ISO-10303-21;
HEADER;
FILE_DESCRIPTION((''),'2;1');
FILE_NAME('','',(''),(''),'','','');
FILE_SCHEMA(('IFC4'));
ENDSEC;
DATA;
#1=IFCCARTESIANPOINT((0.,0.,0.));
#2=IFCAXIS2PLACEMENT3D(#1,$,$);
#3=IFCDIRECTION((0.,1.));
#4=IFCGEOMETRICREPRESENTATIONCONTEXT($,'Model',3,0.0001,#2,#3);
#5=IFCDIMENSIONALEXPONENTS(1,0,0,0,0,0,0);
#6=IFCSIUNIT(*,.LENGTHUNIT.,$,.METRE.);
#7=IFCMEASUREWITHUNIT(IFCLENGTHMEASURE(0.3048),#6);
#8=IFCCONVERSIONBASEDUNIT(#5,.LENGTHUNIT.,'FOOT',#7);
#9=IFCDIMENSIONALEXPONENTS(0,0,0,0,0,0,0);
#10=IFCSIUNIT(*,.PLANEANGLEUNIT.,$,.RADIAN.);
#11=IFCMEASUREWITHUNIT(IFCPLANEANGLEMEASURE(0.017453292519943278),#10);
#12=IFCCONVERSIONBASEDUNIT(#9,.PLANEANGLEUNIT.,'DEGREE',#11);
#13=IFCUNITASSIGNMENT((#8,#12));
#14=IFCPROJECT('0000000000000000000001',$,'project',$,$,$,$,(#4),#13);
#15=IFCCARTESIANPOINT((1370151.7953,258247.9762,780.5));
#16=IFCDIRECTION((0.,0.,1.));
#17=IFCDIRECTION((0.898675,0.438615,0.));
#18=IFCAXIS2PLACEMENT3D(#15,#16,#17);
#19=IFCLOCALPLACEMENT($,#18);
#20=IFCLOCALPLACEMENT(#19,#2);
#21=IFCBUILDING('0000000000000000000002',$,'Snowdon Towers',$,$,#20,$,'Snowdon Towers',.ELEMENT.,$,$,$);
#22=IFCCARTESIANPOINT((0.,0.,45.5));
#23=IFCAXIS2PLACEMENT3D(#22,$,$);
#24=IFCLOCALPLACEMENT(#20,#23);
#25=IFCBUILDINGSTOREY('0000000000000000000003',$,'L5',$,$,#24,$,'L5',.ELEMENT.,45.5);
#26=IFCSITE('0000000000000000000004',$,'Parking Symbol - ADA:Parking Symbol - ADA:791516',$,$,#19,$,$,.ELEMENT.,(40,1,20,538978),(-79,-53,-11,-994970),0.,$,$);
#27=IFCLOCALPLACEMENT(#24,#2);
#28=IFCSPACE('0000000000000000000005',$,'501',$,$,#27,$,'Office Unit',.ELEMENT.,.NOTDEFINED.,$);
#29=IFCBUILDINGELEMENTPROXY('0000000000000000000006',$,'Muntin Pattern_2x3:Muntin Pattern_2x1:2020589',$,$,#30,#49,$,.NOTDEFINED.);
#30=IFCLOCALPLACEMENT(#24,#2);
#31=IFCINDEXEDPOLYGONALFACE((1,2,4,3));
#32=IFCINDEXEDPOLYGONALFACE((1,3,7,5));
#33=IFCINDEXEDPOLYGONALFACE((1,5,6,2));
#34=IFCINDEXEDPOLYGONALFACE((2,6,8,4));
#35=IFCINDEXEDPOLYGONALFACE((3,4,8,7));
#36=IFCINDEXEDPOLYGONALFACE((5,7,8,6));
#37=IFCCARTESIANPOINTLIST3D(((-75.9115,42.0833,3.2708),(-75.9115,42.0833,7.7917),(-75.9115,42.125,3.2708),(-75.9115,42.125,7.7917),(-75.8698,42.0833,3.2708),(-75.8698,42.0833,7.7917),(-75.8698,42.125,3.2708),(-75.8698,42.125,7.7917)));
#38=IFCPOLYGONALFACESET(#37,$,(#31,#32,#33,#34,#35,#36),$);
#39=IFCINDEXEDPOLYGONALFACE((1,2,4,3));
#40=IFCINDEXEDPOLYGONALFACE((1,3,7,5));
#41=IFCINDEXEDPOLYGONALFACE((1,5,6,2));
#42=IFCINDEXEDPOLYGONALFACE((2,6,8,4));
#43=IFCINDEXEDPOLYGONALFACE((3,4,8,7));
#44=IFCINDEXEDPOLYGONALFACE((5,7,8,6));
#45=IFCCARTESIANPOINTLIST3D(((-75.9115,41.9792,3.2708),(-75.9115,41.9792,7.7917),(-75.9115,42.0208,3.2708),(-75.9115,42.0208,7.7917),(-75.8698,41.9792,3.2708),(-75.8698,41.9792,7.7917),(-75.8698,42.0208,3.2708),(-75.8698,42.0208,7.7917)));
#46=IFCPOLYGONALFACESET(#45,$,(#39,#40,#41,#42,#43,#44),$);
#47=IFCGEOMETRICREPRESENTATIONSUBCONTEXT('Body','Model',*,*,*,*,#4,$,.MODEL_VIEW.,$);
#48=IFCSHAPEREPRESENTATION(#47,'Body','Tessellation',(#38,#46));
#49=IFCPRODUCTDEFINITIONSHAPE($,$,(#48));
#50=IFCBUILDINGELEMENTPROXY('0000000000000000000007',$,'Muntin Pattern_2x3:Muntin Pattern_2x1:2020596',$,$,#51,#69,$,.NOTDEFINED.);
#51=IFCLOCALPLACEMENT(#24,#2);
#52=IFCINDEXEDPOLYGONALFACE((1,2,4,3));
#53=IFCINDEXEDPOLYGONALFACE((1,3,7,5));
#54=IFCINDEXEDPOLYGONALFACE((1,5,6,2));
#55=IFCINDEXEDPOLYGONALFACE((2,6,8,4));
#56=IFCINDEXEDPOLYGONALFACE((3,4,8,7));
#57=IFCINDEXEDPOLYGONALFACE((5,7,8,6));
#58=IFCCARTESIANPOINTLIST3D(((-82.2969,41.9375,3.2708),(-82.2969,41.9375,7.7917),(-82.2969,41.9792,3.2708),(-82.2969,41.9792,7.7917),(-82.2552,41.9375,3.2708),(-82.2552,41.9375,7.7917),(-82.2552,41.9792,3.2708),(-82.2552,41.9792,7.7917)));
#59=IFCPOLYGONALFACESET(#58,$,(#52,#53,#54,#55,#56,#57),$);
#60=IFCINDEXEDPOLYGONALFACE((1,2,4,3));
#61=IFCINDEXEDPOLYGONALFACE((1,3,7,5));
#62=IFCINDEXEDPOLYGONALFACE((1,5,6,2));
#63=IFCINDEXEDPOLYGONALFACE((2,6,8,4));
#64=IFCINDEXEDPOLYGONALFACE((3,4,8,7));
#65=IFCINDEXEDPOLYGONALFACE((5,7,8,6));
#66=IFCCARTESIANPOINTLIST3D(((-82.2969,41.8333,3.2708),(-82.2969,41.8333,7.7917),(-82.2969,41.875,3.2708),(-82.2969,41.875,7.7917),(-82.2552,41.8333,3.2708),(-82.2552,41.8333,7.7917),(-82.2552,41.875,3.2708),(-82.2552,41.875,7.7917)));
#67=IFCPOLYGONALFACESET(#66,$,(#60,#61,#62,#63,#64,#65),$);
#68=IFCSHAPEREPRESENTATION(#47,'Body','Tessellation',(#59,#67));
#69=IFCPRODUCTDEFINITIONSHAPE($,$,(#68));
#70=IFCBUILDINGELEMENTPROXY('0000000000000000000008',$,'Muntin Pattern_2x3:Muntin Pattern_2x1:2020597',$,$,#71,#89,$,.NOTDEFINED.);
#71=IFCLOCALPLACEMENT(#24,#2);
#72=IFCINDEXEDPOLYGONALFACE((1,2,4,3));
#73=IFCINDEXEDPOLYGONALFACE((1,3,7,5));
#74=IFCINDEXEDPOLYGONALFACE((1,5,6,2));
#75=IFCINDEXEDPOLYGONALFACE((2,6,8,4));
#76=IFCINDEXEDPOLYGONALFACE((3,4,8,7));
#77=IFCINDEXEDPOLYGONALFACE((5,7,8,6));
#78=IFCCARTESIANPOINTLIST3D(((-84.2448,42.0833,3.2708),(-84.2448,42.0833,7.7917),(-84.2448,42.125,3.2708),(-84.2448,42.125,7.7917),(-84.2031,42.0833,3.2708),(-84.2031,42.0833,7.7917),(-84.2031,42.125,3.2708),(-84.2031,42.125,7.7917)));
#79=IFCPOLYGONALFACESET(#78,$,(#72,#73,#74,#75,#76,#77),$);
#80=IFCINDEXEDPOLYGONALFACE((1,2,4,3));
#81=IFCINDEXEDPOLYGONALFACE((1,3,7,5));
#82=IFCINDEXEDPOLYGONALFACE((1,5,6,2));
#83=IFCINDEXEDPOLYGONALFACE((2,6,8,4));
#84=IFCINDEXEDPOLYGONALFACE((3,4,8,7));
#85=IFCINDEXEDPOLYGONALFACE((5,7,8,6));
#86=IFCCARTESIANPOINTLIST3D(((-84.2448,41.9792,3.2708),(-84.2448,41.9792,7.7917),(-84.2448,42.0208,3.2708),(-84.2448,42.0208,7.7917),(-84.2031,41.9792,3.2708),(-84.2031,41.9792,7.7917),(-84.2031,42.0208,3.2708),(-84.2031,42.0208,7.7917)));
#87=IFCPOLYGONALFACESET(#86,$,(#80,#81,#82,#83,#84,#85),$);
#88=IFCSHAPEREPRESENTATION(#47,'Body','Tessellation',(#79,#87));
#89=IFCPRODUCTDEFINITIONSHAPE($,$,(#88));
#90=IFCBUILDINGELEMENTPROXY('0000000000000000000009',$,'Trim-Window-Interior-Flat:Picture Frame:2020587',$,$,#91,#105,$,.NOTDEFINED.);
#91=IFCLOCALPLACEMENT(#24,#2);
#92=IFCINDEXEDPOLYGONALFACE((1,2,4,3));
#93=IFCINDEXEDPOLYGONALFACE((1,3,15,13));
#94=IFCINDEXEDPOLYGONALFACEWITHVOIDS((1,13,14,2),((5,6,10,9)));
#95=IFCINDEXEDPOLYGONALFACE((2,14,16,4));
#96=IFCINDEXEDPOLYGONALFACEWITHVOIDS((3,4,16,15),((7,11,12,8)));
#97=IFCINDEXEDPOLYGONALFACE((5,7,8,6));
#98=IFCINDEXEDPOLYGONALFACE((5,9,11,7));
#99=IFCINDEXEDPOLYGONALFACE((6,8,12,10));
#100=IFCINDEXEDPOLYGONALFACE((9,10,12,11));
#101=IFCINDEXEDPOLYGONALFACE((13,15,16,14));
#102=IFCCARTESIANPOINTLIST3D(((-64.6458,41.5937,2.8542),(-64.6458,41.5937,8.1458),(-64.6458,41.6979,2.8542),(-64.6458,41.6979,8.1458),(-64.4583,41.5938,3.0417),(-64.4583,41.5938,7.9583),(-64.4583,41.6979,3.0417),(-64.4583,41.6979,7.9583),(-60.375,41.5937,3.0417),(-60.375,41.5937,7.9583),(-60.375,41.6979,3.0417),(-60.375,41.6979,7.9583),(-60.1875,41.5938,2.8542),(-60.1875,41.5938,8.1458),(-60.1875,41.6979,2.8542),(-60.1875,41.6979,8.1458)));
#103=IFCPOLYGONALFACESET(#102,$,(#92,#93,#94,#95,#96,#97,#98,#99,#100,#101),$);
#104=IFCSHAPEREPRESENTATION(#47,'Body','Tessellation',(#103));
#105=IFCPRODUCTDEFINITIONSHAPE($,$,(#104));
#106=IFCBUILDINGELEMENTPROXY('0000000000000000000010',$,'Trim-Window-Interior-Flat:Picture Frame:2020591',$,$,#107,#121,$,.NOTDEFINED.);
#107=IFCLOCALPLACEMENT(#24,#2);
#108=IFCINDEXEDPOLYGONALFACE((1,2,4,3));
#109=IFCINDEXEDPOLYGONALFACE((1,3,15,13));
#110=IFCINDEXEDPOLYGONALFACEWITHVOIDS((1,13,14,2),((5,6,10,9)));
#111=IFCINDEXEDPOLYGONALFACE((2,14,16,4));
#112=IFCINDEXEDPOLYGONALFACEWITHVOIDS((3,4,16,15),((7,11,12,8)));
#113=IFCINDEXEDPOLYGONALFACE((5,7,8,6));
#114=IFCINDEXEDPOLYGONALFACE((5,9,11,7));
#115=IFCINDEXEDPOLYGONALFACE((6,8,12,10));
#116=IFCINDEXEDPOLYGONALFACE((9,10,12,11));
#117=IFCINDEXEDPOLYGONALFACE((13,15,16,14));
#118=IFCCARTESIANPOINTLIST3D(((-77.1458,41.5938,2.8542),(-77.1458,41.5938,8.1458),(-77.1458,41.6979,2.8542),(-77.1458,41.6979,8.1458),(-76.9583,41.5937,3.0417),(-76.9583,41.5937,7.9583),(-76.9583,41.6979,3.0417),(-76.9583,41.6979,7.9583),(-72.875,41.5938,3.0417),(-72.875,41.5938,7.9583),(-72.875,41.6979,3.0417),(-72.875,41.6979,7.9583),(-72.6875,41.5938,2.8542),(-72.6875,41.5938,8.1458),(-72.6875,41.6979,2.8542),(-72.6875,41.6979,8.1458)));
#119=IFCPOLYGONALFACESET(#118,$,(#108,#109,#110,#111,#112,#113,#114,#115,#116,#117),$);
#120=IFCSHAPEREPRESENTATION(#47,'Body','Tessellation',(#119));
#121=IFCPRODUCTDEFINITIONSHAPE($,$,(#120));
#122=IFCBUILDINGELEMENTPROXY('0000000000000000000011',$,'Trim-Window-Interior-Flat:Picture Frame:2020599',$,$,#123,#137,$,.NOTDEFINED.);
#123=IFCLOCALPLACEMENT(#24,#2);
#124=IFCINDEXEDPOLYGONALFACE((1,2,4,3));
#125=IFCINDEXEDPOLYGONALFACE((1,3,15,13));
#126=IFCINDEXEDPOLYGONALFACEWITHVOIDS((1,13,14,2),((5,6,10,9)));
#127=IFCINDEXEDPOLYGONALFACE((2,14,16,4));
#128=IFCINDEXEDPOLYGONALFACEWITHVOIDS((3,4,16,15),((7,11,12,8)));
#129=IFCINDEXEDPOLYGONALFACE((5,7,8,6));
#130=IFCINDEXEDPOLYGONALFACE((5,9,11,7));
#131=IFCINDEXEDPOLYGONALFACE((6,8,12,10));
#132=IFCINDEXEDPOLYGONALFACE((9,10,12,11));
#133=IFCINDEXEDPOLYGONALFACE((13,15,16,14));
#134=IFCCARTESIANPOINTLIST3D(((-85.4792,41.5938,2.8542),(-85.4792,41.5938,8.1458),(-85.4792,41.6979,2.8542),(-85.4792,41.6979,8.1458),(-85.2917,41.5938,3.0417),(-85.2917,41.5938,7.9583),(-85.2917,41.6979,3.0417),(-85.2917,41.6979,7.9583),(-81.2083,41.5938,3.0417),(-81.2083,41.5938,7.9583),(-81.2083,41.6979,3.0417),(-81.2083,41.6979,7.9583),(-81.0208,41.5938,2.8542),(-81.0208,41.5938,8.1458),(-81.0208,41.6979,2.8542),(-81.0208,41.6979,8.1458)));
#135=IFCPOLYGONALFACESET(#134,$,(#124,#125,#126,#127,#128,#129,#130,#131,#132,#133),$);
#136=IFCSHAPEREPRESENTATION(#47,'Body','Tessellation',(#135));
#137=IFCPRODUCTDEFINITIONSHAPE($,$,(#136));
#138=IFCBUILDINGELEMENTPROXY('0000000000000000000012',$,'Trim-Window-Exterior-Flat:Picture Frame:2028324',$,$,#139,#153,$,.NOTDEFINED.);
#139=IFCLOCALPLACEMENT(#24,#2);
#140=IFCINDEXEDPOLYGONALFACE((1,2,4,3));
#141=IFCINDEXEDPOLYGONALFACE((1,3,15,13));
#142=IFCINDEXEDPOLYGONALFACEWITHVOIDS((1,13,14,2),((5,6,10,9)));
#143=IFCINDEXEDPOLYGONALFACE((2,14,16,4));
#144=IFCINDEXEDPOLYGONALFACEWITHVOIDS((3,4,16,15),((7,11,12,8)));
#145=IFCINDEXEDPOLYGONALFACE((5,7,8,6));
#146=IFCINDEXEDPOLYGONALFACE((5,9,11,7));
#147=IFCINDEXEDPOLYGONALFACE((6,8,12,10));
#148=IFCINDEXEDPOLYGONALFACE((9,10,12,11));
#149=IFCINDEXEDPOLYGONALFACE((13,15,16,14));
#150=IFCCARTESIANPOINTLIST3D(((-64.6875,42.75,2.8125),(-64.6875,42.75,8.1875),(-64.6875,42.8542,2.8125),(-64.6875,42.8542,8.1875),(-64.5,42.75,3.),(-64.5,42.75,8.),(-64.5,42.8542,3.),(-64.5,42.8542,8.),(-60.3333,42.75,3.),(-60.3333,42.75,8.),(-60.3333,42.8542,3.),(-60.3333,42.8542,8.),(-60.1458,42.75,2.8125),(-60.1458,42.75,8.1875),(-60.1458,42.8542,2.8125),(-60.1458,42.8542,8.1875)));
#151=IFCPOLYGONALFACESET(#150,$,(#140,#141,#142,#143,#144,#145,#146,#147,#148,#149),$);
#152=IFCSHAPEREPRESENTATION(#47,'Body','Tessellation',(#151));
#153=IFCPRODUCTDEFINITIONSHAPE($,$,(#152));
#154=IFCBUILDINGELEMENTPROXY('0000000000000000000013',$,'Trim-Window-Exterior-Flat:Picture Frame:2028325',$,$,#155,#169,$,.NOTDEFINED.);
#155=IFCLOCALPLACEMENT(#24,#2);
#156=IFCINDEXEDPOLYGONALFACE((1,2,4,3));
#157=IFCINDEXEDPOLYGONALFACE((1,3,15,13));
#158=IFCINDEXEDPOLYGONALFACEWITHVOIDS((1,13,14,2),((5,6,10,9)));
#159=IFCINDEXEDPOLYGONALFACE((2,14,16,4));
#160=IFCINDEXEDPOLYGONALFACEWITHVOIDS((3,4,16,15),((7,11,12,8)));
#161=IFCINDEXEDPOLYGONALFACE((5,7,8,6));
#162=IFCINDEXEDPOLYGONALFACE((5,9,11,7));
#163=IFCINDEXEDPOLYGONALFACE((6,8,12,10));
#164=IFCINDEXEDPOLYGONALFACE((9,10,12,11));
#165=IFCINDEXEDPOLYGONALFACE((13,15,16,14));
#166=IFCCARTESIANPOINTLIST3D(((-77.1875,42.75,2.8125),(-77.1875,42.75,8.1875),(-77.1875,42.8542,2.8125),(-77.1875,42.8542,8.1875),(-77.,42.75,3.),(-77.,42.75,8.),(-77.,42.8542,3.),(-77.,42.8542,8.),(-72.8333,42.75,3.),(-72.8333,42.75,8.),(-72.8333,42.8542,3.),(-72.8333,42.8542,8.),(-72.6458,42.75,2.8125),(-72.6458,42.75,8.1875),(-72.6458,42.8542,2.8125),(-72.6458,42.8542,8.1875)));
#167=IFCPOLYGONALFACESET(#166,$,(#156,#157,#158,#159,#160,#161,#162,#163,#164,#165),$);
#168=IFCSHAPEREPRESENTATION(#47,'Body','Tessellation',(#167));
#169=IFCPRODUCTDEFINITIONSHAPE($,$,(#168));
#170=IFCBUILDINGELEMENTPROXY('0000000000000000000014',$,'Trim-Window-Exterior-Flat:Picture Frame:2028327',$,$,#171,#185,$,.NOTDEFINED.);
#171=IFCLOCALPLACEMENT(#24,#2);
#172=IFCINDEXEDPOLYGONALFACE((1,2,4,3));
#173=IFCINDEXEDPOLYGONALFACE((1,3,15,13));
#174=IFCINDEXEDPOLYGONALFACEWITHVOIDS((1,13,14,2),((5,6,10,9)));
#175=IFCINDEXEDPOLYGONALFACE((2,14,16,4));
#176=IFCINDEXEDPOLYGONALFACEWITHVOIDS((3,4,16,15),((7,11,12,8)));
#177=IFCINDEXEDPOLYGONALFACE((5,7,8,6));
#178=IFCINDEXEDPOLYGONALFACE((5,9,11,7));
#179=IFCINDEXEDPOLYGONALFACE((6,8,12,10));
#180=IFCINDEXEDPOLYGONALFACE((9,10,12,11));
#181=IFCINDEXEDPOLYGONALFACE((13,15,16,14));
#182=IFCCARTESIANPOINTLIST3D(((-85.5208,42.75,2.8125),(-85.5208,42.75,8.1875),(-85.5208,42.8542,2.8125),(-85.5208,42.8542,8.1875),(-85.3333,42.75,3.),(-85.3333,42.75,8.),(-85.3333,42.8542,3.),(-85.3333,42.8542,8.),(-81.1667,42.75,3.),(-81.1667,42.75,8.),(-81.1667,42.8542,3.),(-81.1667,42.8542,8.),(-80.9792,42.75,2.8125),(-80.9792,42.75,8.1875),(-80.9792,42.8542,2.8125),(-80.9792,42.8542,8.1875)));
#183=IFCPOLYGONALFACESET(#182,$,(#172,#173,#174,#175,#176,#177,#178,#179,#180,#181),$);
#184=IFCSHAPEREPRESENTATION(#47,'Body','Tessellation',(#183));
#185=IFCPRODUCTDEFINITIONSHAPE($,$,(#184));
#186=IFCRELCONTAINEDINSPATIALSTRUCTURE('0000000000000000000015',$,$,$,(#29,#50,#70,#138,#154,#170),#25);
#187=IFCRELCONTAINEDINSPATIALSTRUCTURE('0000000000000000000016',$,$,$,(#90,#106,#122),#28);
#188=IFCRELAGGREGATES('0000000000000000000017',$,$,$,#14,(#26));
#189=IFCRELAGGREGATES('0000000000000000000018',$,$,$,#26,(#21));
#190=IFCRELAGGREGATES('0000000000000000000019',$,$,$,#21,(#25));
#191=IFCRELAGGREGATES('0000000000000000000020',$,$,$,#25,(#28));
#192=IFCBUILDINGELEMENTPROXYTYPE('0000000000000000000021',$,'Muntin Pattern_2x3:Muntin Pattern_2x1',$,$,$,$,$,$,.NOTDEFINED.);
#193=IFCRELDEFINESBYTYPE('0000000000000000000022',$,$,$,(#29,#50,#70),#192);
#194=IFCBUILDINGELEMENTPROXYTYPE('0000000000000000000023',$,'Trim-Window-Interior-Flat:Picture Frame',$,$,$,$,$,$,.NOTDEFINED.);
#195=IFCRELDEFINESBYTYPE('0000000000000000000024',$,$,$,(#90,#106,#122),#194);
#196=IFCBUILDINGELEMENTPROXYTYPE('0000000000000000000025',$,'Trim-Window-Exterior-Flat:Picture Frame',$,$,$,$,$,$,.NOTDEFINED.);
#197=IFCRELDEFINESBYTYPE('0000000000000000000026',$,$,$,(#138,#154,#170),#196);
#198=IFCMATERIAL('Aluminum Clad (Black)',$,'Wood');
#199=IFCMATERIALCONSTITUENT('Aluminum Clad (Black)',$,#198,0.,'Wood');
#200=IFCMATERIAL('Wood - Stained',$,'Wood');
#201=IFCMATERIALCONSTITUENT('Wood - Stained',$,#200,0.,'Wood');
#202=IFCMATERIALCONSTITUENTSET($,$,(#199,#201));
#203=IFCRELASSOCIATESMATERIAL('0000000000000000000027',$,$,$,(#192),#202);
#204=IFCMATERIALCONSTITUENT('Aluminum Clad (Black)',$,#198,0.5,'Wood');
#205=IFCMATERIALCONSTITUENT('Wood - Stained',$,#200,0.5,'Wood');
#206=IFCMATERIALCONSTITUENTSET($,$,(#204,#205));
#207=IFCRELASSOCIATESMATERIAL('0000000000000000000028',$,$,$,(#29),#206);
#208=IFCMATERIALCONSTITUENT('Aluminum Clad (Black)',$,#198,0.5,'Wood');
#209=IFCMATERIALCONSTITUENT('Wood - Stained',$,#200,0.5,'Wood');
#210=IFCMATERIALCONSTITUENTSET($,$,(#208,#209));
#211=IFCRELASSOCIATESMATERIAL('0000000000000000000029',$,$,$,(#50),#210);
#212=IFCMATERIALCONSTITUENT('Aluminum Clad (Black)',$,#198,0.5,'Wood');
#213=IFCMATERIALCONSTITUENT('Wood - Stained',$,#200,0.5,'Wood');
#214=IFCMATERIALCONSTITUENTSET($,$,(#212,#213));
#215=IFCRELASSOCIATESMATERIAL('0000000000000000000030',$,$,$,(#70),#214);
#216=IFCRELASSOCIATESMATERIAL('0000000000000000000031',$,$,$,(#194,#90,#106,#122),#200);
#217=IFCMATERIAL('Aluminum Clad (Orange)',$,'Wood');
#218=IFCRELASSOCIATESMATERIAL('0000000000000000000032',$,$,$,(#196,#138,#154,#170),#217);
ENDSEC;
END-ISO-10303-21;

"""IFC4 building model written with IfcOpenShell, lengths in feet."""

from ifc_helpers import new_model, entity, si_unit, converted_unit, direction, frame, origin, place, context, subcontext, project, spatial, indexed_curve, outline, extrude, source, transform, mapped, material, constituent, constituent_set, type_object, type_shapes, element, save


model = new_model("IFC4")

# Units and contexts
model_context = context("Model", 3, precision=0.0001, world=origin(), true_north=direction((0.0, 1.0)))
body_context = subcontext(model_context, "Body", "Model", "MODEL_VIEW")
ifc_project = project(units=[converted_unit("LENGTHUNIT", "FOOT", entity("IfcLengthMeasure", 0.3048), si_unit("LENGTHUNIT", "METRE"), dimensions=[1, 0, 0, 0, 0, 0, 0]), converted_unit("PLANEANGLEUNIT", "DEGREE", entity("IfcPlaneAngleMeasure", 0.017453292519943278), si_unit("PLANEANGLEUNIT", "RADIAN"), dimensions=[0, 0, 0, 0, 0, 0, 0])], contexts=[model_context])

# Site, building, storey
site_placement = place(None, frame((1370151.7953, 258247.9762, 780.5), z_axis=(0.0, 0.0, 1.0), x_axis=(0.898675, 0.438615, 0.0)))
site = spatial("IfcSite", under=ifc_project, at=site_placement, Name="Parking Symbol - ADA:Parking Symbol - ADA:791516", CompositionType="ELEMENT", RefLatitude=(40, 1, 20, 538978), RefLongitude=(-79, -53, -11, -994970), RefElevation=0.0)
building_placement = place(site_placement, origin())
building = spatial("IfcBuilding", under=site, at=building_placement, Name="Snowdon Towers", LongName="Snowdon Towers", CompositionType="ELEMENT")
storey_placement = place(building_placement, frame((0.0, 0.0, 45.5)))
storey = spatial("IfcBuildingStorey", under=building, at=storey_placement, Name="L5", LongName="L5", CompositionType="ELEMENT", Elevation=45.5)

# Building element proxies
ifc_material_1 = material(Name="Aluminum Clad (Black)", Category="Wood")
ifc_material_2 = material(Name="Wood - Stained", Category="Wood")
ifc_constituent_1 = constituent(ifc_material_1, Name="Aluminum Clad (Black)", Category="Wood", fraction=0.0)
ifc_constituent_2 = constituent(ifc_material_2, Name="Wood - Stained", Category="Wood", fraction=0.0)
ifc_constituent_set_1 = constituent_set(constituents=[ifc_constituent_1, ifc_constituent_2])
building_element_proxy_type_1 = type_object("IfcBuildingElementProxyType", Name="Muntin Pattern_2x3:Muntin Pattern_2x1", PredefinedType="NOTDEFINED", material=ifc_constituent_set_1)
shared_shape_1 = source(origin(), body_context, "Body", "SweptSolid", [
    extrude(outline(indexed_curve([(-0.0208, -0.0208), (0.0208, -0.0208), (0.0208, 0.0208), (-0.0208, 0.0208), (-0.0208, -0.0208)], self_intersect=False)), frame((0.0, 0.0521, 0.0), z_axis=(0.0, 0.0, 1.0), x_axis=(0.0, -1.0, 0.0)), (0.0, 0.0, 1.0), 4.5208),
    extrude(outline(indexed_curve([(-0.0208, -0.0208), (0.0208, -0.0208), (0.0208, 0.0208), (-0.0208, 0.0208), (-0.0208, -0.0208)], self_intersect=False)), frame((0.0, -0.0521, 0.0), z_axis=(0.0, 0.0, 1.0), x_axis=(0.0, -1.0, 0.0)), (0.0, 0.0, 1.0), 4.5208),
])
type_shapes(building_element_proxy_type_1, [shared_shape_1])
ifc_constituent_3 = constituent(ifc_material_1, Name="Aluminum Clad (Black)", Category="Wood", fraction=0.5)
ifc_constituent_4 = constituent(ifc_material_2, Name="Wood - Stained", Category="Wood", fraction=0.5)
ifc_constituent_set_2 = constituent_set(constituents=[ifc_constituent_3, ifc_constituent_4])
proxy_1_placement = place(storey_placement, frame((-75.8906, 42.0521, 3.2708)))
element("IfcBuildingElementProxy", 1, at=proxy_1_placement, inside=storey, type_object=building_element_proxy_type_1, material=ifc_constituent_set_2, Name="Muntin Pattern_2x3:Muntin Pattern_2x1:2020589", PredefinedType="NOTDEFINED", context=body_context, shape_type="MappedRepresentation", body=[
    mapped(shared_shape_1, transform((0.0, 0.0, 0.0), scale=1.0)),
])
ifc_constituent_5 = constituent(ifc_material_1, Name="Aluminum Clad (Black)", Category="Wood", fraction=0.5)
ifc_constituent_6 = constituent(ifc_material_2, Name="Wood - Stained", Category="Wood", fraction=0.5)
ifc_constituent_set_3 = constituent_set(constituents=[ifc_constituent_5, ifc_constituent_6])
proxy_2_placement = place(storey_placement, frame((-82.276, 41.9063, 3.2708)))
element("IfcBuildingElementProxy", 2, at=proxy_2_placement, inside=storey, type_object=building_element_proxy_type_1, material=ifc_constituent_set_3, Name="Muntin Pattern_2x3:Muntin Pattern_2x1:2020596", PredefinedType="NOTDEFINED", context=body_context, shape_type="MappedRepresentation", body=[
    mapped(shared_shape_1, transform((0.0, 0.0, 0.0), scale=1.0)),
])
ifc_constituent_7 = constituent(ifc_material_1, Name="Aluminum Clad (Black)", Category="Wood", fraction=0.5)
ifc_constituent_8 = constituent(ifc_material_2, Name="Wood - Stained", Category="Wood", fraction=0.5)
ifc_constituent_set_4 = constituent_set(constituents=[ifc_constituent_7, ifc_constituent_8])
proxy_3_placement = place(storey_placement, frame((-84.224, 42.0521, 3.2708)))
element("IfcBuildingElementProxy", 3, at=proxy_3_placement, inside=storey, type_object=building_element_proxy_type_1, material=ifc_constituent_set_4, Name="Muntin Pattern_2x3:Muntin Pattern_2x1:2020597", PredefinedType="NOTDEFINED", context=body_context, shape_type="MappedRepresentation", body=[
    mapped(shared_shape_1, transform((0.0, 0.0, 0.0), scale=1.0)),
])

# Shared definitions
space_placement = place(storey_placement, origin())
space = spatial("IfcSpace", under=storey, at=space_placement, Name="501", LongName="Office Unit", CompositionType="ELEMENT", PredefinedType="NOTDEFINED")

# Building element proxies
building_element_proxy_type_2 = type_object("IfcBuildingElementProxyType", Name="Trim-Window-Interior-Flat:Picture Frame", PredefinedType="NOTDEFINED", material=ifc_material_2)
shared_shape_2 = source(origin(), body_context, "Body", "SweptSolid", [
    extrude(outline(indexed_curve([(-2.2292, -2.6458), (2.2292, -2.6458), (2.2292, 2.6458), (-2.2292, 2.6458), (-2.2292, -2.6458)], self_intersect=False), holes=[indexed_curve([(-2.0417, -2.4583), (-2.0417, 2.4583), (2.0417, 2.4583), (2.0417, -2.4583), (-2.0417, -2.4583)], self_intersect=False)]), frame((0.0, -2.5, 0.0), z_axis=(0.0, 0.0, 1.0), x_axis=(-1.0, 0.0, 0.0)), (0.0, 0.0, 1.0), 0.1042),
])
type_shapes(building_element_proxy_type_2, [shared_shape_2])
for number, where, z_axis, x_axis, name in (
    (4, (-62.4167, 41.6979, 8.0), (0.0, -1.0, 0.0), (1.0, 0.0, 0.0), "Trim-Window-Interior-Flat:Picture Frame:2020587"),
    (5, (-74.9167, 41.6979, 8.0), (0.0, -1.0, 0.0), (1.0, 0.0, 0.0), "Trim-Window-Interior-Flat:Picture Frame:2020591"),
    (6, (-83.25, 41.6979, 8.0), (0.0, -1.0, 0.0), (1.0, 0.0, 0.0), "Trim-Window-Interior-Flat:Picture Frame:2020599"),
):
    element("IfcBuildingElementProxy", number, at=place(space_placement, frame(where, z_axis=z_axis, x_axis=x_axis)), inside=space, type_object=building_element_proxy_type_2, material=ifc_material_2, Name=name, PredefinedType="NOTDEFINED", context=body_context, shape_type="MappedRepresentation", body=[
        mapped(shared_shape_2, transform((0.0, 0.0, 0.0), scale=1.0)),
    ])
ifc_material_3 = material(Name="Aluminum Clad (Orange)", Category="Wood")
building_element_proxy_type_3 = type_object("IfcBuildingElementProxyType", Name="Trim-Window-Exterior-Flat:Picture Frame", PredefinedType="NOTDEFINED", material=ifc_material_3)
shared_shape_3 = source(origin(), body_context, "Body", "SweptSolid", [
    extrude(outline(indexed_curve([(-2.2708, -2.6875), (2.2708, -2.6875), (2.2708, 2.6875), (-2.2708, 2.6875), (-2.2708, -2.6875)], self_intersect=False), holes=[indexed_curve([(-2.0833, -2.5), (-2.0833, 2.5), (2.0833, 2.5), (2.0833, -2.5), (-2.0833, -2.5)], self_intersect=False)]), frame((0.0, -2.5, 0.0), z_axis=(0.0, 0.0, 1.0), x_axis=(-1.0, 0.0, 0.0)), (0.0, 0.0, 1.0), 0.1042),
])
type_shapes(building_element_proxy_type_3, [shared_shape_3])
for number, where, z_axis, x_axis, name in (
    (7, (-62.4167, 42.75, 8.0), (0.0, 1.0, 0.0), (-1.0, 0.0, 0.0), "Trim-Window-Exterior-Flat:Picture Frame:2028324"),
    (8, (-74.9167, 42.75, 8.0), (0.0, 1.0, 0.0), (-1.0, 0.0, 0.0), "Trim-Window-Exterior-Flat:Picture Frame:2028325"),
    (9, (-83.25, 42.75, 8.0), (0.0, 1.0, 0.0), (-1.0, 0.0, 0.0), "Trim-Window-Exterior-Flat:Picture Frame:2028327"),
):
    element("IfcBuildingElementProxy", number, at=place(storey_placement, frame(where, z_axis=z_axis, x_axis=x_axis)), inside=storey, type_object=building_element_proxy_type_3, material=ifc_material_3, Name=name, PredefinedType="NOTDEFINED", context=body_context, shape_type="MappedRepresentation", body=[
        mapped(shared_shape_3, transform((0.0, 0.0, 0.0), scale=1.0)),
    ])

save(model, "model.ifc")
